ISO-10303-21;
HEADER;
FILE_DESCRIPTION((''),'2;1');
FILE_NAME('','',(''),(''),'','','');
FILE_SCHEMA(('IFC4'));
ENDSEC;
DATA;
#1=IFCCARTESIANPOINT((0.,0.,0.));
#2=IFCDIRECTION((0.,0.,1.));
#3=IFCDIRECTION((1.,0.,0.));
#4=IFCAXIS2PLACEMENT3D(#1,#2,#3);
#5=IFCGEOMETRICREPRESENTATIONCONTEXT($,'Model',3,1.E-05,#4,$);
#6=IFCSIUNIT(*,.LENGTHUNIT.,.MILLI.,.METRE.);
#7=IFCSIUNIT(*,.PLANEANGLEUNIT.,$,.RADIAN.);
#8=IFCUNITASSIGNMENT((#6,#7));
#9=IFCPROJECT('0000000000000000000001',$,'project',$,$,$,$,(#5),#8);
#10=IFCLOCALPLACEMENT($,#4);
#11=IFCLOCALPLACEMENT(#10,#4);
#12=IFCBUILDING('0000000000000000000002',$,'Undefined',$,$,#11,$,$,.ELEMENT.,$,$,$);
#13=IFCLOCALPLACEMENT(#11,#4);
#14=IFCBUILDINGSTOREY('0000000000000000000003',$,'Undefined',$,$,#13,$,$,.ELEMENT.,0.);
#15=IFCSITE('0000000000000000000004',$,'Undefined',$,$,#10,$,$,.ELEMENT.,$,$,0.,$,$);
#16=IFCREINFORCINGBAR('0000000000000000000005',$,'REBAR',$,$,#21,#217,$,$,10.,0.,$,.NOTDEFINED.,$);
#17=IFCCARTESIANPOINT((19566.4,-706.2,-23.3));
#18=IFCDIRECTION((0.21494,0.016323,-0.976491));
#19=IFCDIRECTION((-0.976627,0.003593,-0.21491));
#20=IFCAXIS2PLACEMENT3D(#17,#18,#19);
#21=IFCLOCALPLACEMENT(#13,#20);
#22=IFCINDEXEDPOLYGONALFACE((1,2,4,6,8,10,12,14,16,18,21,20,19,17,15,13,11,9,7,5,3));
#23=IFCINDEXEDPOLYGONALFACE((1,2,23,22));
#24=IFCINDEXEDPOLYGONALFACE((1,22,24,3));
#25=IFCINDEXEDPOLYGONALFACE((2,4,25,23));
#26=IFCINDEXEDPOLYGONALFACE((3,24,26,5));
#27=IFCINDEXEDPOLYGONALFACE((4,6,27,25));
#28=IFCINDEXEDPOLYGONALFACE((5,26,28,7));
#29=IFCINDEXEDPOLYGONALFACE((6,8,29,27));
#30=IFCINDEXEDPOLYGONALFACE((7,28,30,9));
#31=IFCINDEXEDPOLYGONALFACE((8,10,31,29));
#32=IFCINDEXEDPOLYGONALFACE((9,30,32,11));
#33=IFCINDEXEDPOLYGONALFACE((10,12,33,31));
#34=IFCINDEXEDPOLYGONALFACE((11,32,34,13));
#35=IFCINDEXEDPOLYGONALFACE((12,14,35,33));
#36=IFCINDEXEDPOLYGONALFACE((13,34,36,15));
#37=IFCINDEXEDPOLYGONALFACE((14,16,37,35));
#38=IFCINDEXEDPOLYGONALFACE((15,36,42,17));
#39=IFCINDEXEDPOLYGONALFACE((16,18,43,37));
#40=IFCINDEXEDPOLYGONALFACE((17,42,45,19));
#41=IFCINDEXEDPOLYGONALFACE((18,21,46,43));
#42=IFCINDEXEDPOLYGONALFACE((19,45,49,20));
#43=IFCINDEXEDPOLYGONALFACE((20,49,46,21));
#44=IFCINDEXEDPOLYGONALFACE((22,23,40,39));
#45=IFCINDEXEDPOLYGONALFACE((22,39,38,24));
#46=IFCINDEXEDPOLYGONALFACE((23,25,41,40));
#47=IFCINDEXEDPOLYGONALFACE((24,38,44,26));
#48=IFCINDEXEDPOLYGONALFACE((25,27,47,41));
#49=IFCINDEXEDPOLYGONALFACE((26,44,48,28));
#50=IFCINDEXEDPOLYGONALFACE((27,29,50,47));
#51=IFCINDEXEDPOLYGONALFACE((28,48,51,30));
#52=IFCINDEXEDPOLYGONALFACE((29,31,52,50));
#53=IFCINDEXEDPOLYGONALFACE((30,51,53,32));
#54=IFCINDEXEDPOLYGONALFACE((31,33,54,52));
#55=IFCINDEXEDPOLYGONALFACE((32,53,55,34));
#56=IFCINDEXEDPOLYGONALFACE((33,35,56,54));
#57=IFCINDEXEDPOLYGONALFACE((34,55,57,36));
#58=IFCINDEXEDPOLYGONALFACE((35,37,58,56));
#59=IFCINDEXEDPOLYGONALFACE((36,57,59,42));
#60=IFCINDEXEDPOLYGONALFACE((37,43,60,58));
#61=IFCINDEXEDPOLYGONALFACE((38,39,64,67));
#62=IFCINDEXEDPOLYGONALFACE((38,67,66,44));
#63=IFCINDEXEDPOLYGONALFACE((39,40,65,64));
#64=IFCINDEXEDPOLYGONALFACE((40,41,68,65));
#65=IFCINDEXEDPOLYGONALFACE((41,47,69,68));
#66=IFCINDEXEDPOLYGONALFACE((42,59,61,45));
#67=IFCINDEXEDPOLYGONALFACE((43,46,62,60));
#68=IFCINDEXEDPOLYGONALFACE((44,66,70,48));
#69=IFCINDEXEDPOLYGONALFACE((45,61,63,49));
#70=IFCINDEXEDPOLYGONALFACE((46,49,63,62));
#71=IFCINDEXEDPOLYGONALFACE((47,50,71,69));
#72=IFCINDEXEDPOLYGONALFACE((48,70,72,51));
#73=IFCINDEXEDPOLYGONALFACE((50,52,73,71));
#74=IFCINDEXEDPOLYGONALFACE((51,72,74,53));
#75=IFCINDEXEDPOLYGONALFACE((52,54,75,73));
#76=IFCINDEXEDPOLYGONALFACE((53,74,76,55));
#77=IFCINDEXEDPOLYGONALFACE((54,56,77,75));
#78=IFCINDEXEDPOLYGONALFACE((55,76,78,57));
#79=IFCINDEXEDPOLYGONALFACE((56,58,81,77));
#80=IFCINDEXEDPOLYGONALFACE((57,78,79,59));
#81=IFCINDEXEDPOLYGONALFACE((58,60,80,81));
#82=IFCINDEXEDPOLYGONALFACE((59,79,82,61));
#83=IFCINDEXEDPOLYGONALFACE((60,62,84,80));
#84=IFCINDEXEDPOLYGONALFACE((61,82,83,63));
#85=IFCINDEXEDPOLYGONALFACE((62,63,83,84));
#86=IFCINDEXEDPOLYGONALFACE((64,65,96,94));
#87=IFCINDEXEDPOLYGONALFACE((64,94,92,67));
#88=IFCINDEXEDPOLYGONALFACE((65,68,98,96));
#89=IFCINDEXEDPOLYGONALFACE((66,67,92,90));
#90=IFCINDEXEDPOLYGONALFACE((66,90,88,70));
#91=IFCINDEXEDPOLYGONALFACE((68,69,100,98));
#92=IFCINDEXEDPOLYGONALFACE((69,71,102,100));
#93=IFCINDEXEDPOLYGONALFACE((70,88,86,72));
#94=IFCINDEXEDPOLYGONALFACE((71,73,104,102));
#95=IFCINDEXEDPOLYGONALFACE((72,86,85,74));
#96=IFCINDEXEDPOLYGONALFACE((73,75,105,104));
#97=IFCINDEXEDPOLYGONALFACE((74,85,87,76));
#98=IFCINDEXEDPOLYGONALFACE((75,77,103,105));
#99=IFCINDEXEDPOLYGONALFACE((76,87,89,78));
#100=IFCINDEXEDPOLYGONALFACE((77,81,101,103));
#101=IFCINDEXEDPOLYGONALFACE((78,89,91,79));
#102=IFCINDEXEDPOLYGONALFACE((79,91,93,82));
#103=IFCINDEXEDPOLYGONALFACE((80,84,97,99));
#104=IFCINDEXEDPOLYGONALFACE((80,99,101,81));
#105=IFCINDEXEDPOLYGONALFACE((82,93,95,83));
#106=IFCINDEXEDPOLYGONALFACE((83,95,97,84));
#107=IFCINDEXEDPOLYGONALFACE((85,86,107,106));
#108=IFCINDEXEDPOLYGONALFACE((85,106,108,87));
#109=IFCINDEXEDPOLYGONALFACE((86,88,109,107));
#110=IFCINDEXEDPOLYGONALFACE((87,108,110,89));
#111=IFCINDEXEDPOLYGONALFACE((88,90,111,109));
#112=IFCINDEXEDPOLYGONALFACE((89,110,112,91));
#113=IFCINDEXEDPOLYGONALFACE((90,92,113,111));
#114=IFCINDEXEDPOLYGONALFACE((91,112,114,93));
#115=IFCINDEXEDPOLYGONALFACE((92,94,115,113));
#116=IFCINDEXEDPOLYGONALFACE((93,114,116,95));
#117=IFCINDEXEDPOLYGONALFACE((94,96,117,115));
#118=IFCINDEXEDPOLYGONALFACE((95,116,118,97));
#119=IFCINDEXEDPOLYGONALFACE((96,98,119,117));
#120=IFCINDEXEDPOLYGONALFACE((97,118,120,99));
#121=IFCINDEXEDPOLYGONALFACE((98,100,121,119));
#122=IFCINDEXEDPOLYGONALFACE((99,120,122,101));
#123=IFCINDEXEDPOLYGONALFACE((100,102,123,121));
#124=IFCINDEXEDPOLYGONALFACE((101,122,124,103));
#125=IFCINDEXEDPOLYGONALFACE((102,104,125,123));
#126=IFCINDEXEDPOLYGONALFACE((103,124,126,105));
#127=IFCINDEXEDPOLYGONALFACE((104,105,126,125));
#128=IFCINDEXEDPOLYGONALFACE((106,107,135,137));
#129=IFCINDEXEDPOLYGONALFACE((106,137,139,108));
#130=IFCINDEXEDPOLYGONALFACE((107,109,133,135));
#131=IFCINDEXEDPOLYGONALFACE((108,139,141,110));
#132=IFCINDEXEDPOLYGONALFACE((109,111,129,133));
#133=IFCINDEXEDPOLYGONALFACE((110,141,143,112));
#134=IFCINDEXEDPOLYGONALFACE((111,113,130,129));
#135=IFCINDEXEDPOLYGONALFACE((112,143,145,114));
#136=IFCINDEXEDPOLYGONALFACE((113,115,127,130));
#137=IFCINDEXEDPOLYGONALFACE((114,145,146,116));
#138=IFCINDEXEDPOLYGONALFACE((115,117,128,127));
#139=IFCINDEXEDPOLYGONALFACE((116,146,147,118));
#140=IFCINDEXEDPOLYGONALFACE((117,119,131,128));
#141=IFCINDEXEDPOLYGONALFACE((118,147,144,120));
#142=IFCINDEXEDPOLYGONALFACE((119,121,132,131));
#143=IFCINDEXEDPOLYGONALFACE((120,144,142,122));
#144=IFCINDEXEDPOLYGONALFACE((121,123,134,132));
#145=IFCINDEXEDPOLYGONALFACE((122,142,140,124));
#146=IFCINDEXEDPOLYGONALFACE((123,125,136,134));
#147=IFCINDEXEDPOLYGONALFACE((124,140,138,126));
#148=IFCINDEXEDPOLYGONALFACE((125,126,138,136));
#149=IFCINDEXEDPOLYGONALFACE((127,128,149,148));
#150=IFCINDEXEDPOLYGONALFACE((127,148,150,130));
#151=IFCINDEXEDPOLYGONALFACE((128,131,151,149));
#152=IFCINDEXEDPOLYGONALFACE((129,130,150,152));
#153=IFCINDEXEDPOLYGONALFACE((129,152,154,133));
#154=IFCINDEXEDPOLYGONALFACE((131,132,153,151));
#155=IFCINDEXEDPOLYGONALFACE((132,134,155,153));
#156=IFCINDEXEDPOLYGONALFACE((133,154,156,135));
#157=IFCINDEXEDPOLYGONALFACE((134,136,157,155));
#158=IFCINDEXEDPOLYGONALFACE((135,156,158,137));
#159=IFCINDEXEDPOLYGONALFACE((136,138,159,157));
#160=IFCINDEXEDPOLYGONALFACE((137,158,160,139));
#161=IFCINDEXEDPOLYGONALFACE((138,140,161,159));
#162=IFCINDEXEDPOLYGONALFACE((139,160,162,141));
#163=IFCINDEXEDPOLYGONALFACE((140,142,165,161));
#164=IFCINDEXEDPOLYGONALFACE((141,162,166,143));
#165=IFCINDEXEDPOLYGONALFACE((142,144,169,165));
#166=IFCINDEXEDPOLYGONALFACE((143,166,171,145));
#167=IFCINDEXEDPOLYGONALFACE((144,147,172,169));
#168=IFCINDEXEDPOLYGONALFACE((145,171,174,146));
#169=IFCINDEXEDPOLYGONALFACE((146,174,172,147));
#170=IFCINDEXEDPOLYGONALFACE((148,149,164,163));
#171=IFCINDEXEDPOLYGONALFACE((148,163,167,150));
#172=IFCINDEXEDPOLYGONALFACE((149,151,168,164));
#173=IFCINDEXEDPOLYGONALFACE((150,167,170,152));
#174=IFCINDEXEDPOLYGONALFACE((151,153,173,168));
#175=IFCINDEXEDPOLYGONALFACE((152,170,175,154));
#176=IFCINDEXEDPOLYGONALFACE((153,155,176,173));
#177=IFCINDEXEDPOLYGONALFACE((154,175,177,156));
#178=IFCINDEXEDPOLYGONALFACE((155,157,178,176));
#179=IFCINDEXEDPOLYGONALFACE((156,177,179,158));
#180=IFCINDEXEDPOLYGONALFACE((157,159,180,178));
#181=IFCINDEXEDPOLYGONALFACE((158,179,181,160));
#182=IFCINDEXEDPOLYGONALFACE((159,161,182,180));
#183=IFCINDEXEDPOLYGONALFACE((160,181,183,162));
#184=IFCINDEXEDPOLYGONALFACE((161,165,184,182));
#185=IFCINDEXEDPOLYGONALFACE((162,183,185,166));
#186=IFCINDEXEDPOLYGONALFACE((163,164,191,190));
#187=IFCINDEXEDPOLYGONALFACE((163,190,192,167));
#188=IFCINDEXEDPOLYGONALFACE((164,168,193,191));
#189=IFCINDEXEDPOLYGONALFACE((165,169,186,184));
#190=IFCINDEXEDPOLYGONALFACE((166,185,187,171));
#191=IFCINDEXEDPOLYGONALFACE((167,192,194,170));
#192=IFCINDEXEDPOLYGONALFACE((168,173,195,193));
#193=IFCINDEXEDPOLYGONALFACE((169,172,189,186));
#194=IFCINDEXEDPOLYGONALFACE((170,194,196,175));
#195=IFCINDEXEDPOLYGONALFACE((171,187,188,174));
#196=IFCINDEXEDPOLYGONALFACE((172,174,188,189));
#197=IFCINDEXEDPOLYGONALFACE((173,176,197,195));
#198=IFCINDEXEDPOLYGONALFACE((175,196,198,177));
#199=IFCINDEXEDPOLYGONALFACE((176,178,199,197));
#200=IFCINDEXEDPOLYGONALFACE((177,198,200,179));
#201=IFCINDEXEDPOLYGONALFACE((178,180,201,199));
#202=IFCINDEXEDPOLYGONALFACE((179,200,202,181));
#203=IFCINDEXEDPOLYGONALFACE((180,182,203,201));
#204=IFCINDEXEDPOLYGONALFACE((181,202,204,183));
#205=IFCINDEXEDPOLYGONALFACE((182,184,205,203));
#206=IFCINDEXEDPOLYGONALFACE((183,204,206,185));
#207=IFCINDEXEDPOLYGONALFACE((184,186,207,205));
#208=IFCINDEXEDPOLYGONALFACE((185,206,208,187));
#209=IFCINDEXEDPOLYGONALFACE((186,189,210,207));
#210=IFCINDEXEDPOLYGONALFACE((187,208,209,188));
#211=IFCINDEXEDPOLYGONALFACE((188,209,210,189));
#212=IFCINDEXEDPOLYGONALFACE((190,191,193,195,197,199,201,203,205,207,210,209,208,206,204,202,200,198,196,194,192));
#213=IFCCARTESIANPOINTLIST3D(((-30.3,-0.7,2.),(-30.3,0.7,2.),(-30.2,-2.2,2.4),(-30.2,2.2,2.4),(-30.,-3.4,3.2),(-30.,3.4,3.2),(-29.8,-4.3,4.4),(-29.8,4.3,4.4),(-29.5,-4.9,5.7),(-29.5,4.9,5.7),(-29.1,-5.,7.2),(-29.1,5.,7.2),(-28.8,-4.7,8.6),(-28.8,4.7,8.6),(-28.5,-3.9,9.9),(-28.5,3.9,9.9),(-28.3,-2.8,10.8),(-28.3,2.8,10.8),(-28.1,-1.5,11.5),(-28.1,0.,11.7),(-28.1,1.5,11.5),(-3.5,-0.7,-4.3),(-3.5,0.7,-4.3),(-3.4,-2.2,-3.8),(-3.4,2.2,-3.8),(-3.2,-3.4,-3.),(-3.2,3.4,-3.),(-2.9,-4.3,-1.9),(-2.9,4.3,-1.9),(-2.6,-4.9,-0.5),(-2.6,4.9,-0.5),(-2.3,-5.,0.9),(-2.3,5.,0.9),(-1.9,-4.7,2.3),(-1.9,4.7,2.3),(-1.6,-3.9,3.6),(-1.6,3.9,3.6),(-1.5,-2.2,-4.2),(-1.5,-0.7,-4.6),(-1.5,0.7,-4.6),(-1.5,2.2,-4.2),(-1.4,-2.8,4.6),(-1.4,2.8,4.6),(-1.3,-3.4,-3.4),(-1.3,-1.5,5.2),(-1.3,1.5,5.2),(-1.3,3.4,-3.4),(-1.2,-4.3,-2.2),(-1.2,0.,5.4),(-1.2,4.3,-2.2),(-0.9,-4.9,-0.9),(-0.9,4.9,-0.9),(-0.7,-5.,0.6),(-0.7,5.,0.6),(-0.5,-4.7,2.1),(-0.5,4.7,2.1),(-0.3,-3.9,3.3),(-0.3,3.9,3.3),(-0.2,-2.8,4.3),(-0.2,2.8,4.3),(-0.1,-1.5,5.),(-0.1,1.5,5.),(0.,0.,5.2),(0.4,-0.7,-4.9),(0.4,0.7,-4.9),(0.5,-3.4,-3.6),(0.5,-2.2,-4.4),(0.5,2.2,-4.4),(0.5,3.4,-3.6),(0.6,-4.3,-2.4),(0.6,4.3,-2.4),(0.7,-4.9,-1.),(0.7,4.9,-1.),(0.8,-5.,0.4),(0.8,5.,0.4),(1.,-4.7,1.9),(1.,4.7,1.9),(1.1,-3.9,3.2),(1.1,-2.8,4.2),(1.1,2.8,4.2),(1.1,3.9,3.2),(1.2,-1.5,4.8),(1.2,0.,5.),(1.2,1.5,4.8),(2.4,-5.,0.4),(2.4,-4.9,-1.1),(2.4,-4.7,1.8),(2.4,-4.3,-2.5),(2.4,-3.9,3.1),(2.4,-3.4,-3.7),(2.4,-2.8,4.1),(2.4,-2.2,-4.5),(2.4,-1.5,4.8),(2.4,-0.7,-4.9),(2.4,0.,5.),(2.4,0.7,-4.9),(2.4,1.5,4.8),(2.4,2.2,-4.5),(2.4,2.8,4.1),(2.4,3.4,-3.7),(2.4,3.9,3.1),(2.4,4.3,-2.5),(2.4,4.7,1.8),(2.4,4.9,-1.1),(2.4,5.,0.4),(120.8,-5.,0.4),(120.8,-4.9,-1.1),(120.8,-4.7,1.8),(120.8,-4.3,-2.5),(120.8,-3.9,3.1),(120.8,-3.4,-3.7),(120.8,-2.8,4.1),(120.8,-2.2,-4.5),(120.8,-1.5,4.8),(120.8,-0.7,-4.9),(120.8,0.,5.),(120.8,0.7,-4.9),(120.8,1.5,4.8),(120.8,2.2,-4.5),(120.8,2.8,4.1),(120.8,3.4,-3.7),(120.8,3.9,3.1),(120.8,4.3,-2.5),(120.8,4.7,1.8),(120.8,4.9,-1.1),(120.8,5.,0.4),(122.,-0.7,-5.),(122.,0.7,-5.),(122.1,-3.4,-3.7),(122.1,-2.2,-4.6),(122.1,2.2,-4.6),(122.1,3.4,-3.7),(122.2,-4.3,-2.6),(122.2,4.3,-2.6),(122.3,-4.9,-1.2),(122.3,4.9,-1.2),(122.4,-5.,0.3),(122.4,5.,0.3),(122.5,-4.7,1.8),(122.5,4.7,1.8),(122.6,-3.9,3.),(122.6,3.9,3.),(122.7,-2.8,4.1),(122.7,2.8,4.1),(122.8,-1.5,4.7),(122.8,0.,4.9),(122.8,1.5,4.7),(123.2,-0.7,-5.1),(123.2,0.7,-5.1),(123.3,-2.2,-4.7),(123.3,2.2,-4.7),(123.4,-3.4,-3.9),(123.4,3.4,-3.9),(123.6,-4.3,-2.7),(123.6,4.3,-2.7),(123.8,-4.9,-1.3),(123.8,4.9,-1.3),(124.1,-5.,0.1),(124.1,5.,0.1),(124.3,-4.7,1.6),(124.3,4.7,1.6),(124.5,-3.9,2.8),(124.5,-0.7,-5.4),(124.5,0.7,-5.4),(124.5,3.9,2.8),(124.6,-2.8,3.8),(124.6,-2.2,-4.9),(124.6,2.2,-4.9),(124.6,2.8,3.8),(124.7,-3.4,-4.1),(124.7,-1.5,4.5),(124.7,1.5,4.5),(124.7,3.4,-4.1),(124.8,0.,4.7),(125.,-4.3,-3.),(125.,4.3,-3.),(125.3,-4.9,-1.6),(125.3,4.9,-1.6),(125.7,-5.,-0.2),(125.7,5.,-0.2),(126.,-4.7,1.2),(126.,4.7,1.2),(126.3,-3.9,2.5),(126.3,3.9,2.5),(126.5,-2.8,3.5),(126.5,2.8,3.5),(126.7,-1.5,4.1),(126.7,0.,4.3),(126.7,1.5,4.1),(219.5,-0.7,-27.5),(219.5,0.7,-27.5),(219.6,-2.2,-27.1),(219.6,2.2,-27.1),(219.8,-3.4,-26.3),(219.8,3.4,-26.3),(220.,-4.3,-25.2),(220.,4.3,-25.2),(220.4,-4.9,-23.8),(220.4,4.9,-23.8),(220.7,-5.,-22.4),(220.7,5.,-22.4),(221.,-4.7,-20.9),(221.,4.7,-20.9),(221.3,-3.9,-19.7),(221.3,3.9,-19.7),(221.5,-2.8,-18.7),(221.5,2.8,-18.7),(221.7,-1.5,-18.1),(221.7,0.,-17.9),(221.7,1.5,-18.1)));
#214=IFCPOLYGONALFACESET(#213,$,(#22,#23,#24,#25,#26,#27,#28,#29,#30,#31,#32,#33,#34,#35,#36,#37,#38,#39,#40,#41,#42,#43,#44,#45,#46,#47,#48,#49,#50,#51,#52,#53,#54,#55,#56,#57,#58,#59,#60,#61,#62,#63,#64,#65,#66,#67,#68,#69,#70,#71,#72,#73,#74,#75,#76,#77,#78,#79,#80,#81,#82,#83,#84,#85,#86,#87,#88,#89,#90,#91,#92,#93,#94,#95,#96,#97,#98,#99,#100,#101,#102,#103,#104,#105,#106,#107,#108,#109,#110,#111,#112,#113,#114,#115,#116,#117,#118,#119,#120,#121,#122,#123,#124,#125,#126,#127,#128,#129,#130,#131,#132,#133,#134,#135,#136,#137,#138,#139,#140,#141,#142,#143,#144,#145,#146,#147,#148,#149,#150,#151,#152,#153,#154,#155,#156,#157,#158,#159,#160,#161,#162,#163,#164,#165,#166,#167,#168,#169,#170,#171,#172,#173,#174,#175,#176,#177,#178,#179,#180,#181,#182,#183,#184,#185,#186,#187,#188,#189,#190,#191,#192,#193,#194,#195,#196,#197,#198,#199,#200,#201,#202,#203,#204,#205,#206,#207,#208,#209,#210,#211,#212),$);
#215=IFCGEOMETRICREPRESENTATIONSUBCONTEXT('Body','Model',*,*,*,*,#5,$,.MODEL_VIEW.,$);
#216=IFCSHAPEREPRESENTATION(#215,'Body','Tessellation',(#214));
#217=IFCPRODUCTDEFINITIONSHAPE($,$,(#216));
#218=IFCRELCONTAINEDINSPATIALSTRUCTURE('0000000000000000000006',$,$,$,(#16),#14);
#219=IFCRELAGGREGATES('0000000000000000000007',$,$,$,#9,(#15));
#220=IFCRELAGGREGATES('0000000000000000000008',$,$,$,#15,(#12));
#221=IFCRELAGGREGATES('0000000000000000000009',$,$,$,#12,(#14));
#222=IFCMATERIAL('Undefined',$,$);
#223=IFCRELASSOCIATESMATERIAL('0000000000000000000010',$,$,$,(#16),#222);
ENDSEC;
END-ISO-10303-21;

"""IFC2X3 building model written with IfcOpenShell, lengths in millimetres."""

from ifc_helpers import new_model, entity, si_unit, frame, origin_with_axes, place, context, subcontext, project, spatial, source, transform, mapped, material, element, save


model = new_model("IFC2X3")

# Units and contexts
model_context = context("Model", 3, precision=1e-05, world=origin_with_axes())
body_context = subcontext(model_context, "Body", "Model", "MODEL_VIEW")
ifc_project = project(units=[si_unit("LENGTHUNIT", "METRE", prefix="MILLI"), si_unit("PLANEANGLEUNIT", "RADIAN")], contexts=[model_context])

# Site, building, storey
site_placement = place(None, origin_with_axes())
site = spatial("IfcSite", under=ifc_project, at=site_placement, Name="Undefined", CompositionType="ELEMENT", RefElevation=0.0)
building_placement = place(site_placement, origin_with_axes())
building = spatial("IfcBuilding", under=site, at=building_placement, Name="Undefined", CompositionType="ELEMENT")
storey_placement = place(building_placement, origin_with_axes())
storey = spatial("IfcBuildingStorey", under=building, at=storey_placement, Name="Undefined", CompositionType="ELEMENT", Elevation=0.0)

# Reinforcing bar
ifc_material_1 = material(Name="Undefined")
ifc_direction_1 = entity("IfcDirection", [0.973841, 0.0, -0.22723])
shared_shape_1 = source(origin_with_axes(), body_context, "Body", "AdvancedSweptSolid", [
    entity("IfcSweptDiskSolid", entity("IfcCompositeCurve", [entity("IfcCompositeCurveSegment", "CONTINUOUS", True, entity("IfcTrimmedCurve", entity("IfcLine", entity("IfcCartesianPoint", [0.0, 0.0, 0.0]), entity("IfcVector", ifc_direction_1, 1.0)), [entity("IfcParameterValue", 0.0)], [entity("IfcParameterValue", 27.582469)], True, "PARAMETER")), entity("IfcCompositeCurveSegment", "CONTINUOUS", True, entity("IfcTrimmedCurve", entity("IfcCircle", entity("IfcAxis2Placement3D", entity("IfcCartesianPoint", [31.6, 0.0, 14.2]), entity("IfcDirection", [0.0, -1.0, 0.0]), entity("IfcDirection", [-0.22723, 0.0, -0.973841])), 21.0), [entity("IfcParameterValue", 0.0)], [entity("IfcParameterValue", 0.229232)], True, "PARAMETER")), entity("IfcCompositeCurveSegment", "CONTINUOUS", True, entity("IfcTrimmedCurve", entity("IfcLine", entity("IfcCartesianPoint", [31.6, 0.0, -6.8]), entity("IfcVector", entity("IfcDirection", [1.0, 0.0, 0.0]), 1.0)), [entity("IfcParameterValue", 0.0)], [entity("IfcParameterValue", 118.388313)], True, "PARAMETER")), entity("IfcCompositeCurveSegment", "CONTINUOUS", True, entity("IfcTrimmedCurve", entity("IfcCircle", entity("IfcAxis2Placement3D", entity("IfcCartesianPoint", [150.0, 0.0, -27.8]), entity("IfcDirection", [0.0, 1.0, 0.0]), entity("IfcDirection", [0.0, 0.0, 1.0])), 21.0), [entity("IfcParameterValue", 0.0)], [entity("IfcParameterValue", 0.229232)], True, "PARAMETER")), entity("IfcCompositeCurveSegment", "DISCONTINUOUS", True, entity("IfcTrimmedCurve", entity("IfcLine", entity("IfcCartesianPoint", [154.8, 0.0, -7.4]), entity("IfcVector", ifc_direction_1, 1.0)), [entity("IfcParameterValue", 0.0)], [entity("IfcParameterValue", 97.582469)], True, "PARAMETER"))], False), 5.0, None, 0.0, 244.0),
])
reinforcing_bar_1_placement = place(storey_placement, frame((19566.4, -706.2, -23.3), z_axis=(0.21494, 0.016323, -0.976491), x_axis=(-0.976627, 0.003593, -0.21491)))
element("IfcReinforcingBar", 1, at=reinforcing_bar_1_placement, inside=storey, material=ifc_material_1, Name="REBAR", BarRole="NOTDEFINED", CrossSectionArea=0.0, NominalDiameter=10.0, context=body_context, shape_type="MappedRepresentation", body=[
    mapped(shared_shape_1, transform((-29.2, 0.0, 6.8))),
])

save(model, "model.ifc")
